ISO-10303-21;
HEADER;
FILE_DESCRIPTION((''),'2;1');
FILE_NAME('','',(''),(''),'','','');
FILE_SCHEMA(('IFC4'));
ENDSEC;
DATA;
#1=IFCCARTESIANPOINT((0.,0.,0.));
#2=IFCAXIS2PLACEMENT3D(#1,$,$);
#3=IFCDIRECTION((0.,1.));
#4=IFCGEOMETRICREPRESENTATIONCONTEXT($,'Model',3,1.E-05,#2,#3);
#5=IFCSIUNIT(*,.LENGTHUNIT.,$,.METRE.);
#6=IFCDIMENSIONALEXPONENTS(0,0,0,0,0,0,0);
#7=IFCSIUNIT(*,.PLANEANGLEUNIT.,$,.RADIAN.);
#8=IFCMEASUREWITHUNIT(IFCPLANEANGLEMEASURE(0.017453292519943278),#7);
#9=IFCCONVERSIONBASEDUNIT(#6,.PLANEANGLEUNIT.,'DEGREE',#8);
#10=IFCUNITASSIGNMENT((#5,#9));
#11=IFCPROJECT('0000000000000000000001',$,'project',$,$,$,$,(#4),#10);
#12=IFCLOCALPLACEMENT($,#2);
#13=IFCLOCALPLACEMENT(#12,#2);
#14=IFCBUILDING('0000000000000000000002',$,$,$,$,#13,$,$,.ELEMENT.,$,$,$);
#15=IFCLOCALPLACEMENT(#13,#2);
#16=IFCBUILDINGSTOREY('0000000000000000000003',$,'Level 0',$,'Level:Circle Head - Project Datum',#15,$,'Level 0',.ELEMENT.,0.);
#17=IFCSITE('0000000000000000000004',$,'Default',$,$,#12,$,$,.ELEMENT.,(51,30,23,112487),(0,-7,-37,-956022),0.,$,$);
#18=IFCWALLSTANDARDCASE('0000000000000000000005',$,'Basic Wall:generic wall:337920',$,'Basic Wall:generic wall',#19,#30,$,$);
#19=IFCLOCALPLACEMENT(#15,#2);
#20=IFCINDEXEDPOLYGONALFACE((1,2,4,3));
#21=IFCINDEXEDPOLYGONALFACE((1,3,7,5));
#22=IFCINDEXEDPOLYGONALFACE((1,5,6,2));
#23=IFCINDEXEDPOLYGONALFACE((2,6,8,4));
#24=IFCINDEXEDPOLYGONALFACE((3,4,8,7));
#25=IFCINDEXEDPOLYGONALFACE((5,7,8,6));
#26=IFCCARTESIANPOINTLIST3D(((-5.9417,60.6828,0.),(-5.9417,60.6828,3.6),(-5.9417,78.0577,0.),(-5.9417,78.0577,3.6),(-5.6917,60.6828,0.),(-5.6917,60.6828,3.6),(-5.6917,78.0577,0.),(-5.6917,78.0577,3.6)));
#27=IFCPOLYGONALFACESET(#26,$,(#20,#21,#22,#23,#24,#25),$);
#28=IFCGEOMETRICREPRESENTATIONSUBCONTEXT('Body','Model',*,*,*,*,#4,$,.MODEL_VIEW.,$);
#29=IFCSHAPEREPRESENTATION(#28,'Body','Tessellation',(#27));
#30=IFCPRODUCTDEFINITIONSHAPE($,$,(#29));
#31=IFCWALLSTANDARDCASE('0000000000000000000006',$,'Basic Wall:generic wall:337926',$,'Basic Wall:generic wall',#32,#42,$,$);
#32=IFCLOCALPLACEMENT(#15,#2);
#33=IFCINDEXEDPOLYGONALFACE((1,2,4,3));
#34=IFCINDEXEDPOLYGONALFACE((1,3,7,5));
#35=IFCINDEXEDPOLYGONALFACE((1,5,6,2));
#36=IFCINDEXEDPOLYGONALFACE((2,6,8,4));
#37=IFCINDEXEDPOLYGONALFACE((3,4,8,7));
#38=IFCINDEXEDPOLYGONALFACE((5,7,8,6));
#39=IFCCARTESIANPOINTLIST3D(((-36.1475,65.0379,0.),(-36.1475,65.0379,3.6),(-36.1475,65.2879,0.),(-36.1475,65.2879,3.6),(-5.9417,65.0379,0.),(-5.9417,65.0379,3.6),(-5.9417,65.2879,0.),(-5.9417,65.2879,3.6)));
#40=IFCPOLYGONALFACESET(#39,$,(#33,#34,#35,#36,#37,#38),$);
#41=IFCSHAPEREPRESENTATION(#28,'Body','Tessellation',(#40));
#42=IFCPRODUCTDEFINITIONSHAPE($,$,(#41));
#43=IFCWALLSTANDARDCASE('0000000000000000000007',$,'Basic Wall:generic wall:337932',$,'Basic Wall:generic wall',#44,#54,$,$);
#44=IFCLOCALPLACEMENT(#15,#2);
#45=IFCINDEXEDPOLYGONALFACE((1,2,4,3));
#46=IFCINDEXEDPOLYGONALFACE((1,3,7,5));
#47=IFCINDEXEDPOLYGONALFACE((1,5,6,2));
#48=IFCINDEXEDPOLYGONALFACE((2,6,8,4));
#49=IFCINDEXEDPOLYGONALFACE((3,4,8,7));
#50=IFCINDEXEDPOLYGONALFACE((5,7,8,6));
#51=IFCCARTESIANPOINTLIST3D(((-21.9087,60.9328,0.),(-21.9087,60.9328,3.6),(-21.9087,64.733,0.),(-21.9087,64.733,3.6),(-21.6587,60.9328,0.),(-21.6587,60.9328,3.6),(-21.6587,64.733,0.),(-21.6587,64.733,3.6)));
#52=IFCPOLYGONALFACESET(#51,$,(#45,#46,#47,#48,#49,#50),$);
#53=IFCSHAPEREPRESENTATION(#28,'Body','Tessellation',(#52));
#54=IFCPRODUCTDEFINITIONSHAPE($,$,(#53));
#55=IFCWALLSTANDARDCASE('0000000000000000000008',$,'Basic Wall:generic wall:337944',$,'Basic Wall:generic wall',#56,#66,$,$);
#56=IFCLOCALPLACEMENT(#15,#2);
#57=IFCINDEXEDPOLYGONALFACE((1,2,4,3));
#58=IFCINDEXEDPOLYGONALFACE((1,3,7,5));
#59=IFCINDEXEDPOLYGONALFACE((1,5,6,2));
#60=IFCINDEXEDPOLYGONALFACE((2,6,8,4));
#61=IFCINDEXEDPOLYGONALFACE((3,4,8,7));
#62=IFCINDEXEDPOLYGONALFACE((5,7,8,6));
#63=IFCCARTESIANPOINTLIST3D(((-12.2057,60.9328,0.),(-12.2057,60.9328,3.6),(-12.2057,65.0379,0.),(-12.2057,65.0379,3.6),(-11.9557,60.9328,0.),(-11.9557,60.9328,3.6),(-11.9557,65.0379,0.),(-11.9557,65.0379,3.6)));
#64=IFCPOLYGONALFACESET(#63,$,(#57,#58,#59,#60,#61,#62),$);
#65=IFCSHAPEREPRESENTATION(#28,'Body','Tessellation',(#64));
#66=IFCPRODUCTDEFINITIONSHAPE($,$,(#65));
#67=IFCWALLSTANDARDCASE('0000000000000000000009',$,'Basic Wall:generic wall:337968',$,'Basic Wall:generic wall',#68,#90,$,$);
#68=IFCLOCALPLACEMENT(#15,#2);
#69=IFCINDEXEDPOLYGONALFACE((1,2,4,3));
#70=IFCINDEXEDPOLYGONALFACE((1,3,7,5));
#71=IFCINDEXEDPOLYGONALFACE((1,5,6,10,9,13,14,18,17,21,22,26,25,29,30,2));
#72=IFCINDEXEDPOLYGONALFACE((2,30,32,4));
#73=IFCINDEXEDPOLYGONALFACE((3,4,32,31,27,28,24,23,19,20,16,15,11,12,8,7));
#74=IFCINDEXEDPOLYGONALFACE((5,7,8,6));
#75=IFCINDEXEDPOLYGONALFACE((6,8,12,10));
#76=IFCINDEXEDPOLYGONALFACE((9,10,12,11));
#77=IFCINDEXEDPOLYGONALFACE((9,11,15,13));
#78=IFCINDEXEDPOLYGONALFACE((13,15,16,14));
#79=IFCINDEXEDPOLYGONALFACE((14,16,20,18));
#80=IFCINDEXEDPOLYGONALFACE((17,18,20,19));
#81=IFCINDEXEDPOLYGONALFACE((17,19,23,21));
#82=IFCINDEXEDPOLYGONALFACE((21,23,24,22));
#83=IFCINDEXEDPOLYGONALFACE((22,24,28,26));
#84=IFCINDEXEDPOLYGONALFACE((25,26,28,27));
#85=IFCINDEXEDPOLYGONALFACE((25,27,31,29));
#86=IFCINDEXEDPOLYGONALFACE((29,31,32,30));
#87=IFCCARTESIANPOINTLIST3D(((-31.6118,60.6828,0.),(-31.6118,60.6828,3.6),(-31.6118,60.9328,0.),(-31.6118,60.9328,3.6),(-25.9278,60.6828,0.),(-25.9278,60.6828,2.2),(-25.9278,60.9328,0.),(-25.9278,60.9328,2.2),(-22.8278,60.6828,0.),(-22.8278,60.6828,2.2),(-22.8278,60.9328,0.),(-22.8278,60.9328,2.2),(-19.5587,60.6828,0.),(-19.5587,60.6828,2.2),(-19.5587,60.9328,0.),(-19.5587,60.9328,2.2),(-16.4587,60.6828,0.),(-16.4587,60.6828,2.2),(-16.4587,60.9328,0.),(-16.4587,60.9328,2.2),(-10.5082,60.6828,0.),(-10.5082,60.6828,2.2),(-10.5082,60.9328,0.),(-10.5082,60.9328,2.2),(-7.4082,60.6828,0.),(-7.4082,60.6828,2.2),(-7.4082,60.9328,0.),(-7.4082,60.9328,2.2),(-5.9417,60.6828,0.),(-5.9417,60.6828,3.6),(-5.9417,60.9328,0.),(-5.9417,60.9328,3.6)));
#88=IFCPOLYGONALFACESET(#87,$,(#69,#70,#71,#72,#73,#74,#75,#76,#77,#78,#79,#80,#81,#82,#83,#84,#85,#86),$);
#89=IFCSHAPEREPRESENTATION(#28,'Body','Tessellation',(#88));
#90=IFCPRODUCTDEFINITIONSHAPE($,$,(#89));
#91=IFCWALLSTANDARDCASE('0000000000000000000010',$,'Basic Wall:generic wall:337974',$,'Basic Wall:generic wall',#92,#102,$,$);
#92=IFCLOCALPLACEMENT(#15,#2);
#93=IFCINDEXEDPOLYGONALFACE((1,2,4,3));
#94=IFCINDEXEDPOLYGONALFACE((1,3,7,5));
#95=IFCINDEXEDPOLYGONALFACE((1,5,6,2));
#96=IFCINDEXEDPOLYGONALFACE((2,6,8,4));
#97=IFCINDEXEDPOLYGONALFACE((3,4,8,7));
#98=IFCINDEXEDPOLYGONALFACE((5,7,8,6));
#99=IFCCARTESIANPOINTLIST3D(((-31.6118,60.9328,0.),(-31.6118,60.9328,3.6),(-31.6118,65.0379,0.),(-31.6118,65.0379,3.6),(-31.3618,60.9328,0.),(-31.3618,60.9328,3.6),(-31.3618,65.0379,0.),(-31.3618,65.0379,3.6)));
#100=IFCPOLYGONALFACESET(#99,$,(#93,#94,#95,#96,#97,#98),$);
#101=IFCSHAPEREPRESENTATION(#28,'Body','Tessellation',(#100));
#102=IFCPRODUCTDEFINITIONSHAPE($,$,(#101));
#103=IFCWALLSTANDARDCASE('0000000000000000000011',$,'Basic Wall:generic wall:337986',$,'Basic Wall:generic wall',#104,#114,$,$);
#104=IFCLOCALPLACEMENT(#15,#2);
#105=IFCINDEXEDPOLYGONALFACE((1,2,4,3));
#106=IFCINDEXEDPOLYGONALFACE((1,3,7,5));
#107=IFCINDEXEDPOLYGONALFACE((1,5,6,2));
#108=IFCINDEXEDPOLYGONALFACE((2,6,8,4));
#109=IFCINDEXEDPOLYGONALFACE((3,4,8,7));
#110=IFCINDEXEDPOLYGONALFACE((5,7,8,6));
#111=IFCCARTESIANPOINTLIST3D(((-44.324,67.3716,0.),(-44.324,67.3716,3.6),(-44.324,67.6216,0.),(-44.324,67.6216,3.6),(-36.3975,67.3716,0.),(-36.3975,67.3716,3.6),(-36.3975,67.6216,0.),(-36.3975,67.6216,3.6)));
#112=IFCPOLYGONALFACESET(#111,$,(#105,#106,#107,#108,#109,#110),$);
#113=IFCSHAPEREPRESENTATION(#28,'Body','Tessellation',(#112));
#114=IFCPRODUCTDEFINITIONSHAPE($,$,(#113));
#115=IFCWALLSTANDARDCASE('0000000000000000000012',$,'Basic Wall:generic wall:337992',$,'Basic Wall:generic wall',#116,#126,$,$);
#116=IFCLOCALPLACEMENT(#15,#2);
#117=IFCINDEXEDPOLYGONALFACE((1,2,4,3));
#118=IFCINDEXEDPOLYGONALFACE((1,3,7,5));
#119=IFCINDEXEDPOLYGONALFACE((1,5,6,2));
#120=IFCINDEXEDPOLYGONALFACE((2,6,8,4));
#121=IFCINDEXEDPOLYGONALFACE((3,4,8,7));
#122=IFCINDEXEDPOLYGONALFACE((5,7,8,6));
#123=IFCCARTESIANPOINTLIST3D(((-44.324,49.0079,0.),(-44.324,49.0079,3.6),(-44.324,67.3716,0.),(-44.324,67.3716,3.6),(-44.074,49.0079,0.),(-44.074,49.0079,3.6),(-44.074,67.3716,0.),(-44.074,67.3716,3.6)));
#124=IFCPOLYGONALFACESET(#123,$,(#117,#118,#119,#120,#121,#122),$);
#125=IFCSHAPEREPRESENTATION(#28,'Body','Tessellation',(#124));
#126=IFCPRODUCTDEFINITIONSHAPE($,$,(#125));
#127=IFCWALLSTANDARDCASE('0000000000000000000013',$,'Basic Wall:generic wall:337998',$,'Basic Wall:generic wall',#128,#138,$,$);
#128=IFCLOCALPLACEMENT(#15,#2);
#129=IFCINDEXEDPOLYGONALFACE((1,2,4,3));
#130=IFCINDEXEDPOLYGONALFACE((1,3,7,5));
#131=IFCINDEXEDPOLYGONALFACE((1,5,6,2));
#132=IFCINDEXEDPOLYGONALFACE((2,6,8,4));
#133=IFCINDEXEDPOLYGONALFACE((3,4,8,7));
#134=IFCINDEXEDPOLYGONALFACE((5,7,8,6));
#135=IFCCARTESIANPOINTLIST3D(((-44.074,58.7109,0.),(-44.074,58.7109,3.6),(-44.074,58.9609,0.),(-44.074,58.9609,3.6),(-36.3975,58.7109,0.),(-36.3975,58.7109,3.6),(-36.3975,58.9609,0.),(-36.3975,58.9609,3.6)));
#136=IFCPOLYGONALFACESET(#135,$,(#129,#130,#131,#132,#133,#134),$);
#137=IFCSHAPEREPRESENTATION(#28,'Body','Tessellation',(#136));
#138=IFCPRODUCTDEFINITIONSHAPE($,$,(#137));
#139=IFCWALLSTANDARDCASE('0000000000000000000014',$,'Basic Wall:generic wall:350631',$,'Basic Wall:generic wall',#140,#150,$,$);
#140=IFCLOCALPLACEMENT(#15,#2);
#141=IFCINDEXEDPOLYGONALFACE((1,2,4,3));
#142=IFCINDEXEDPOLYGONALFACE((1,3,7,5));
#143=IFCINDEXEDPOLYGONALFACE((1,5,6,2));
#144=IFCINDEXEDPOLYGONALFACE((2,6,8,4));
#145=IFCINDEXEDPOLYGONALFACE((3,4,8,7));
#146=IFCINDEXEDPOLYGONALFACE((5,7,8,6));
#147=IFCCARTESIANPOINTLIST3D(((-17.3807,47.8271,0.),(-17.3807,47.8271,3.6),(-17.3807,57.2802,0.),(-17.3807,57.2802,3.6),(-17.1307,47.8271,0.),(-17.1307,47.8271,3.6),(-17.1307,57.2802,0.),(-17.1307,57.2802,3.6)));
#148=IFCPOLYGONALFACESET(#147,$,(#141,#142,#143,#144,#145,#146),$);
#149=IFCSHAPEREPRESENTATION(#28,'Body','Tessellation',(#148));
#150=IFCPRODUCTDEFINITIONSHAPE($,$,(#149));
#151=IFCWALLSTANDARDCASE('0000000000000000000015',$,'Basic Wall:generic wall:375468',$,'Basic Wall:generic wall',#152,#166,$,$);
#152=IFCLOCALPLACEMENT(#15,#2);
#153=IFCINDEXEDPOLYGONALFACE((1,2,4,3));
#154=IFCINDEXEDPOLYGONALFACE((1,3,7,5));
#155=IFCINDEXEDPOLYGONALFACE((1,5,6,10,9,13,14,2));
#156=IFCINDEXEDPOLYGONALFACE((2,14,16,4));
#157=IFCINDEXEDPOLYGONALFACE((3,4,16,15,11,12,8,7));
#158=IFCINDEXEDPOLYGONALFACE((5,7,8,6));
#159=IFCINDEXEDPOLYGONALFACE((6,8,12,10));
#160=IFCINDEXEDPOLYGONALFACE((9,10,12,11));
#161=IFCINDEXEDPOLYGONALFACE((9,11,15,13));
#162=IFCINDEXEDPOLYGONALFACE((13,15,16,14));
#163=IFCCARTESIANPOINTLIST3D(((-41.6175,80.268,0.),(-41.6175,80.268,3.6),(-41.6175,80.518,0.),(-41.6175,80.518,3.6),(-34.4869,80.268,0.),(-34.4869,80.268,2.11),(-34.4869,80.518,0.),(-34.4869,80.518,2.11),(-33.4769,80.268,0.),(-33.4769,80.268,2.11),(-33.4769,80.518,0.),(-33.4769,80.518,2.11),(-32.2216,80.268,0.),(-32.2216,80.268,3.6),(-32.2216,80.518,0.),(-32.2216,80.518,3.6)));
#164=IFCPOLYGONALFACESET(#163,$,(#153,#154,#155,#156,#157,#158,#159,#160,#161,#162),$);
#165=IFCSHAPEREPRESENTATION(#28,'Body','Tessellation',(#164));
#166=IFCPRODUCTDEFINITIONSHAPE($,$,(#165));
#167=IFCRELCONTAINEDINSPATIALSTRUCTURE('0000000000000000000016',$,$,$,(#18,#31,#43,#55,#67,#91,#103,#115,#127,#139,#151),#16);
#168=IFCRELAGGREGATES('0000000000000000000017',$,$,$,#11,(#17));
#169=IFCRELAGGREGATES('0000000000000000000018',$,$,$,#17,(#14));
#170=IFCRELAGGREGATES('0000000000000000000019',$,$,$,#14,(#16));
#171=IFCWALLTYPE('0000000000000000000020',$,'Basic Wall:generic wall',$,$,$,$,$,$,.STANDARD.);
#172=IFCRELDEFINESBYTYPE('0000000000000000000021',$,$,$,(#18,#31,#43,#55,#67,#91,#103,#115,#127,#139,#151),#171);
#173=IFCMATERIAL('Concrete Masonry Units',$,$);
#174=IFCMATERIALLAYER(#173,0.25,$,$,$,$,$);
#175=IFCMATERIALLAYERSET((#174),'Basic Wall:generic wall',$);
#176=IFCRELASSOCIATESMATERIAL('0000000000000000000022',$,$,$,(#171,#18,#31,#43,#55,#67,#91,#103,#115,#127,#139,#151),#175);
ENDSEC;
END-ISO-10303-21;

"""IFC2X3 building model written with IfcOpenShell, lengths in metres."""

from ifc_helpers import new_model, entity, si_unit, converted_unit, direction, frame, frame_2d, origin, place, context, subcontext, project, spatial, rectangle, extrude, material, layer, layer_set, layer_usage, type_object, element, save


model = new_model("IFC2X3")

# Units and contexts
model_context = context("Model", 3, precision=1e-05, world=origin(), true_north=direction((0.0, 1.0)))
body_context = subcontext(model_context, "Body", "Model", "MODEL_VIEW")
ifc_project = project(units=[si_unit("LENGTHUNIT", "METRE"), converted_unit("PLANEANGLEUNIT", "DEGREE", entity("IfcPlaneAngleMeasure", 0.017453292519943278), si_unit("PLANEANGLEUNIT", "RADIAN"), dimensions=[0, 0, 0, 0, 0, 0, 0])], contexts=[model_context])

# Site, building, storey
site_placement = place(None, origin())
site = spatial("IfcSite", under=ifc_project, at=site_placement, Name="Default", CompositionType="ELEMENT", RefLatitude=(51, 30, 23, 112487), RefLongitude=(0, -7, -37, -956022), RefElevation=0.0)
building_placement = place(site_placement, origin())
building = spatial("IfcBuilding", under=site, at=building_placement, CompositionType="ELEMENT")
storey_placement = place(building_placement, origin())
storey = spatial("IfcBuildingStorey", under=building, at=storey_placement, Name="Level 0", ObjectType="Level:Circle Head - Project Datum", LongName="Level 0", CompositionType="ELEMENT", Elevation=0.0)

# Shared definitions
ifc_material = material(Name="Concrete Masonry Units")
ifc_layer = layer(ifc_material, 0.25)
ifc_layer_set = layer_set([ifc_layer], Name="Basic Wall:generic wall")
wall_type = type_object("IfcWallType", Name="Basic Wall:generic wall", PredefinedType="STANDARD", material=ifc_layer_set)

# Walls
ifc_layer_usage_1 = layer_usage(ifc_layer_set, "AXIS2", "NEGATIVE", 0.125)
wall_1_placement = place(storey_placement, frame((-5.8167, 78.0577, 0.0), z_axis=(0.0, 0.0, 1.0), x_axis=(0.0, -1.0, 0.0)))
element("IfcWallStandardCase", 1, at=wall_1_placement, inside=storey, type_object=wall_type, material=ifc_layer_usage_1, Name="Basic Wall:generic wall:337920", ObjectType="Basic Wall:generic wall", context=body_context, shape_type="SweptSolid", body=[
    extrude(rectangle(XDim=17.3749, YDim=0.25, at=frame_2d((8.6874, 0.0), x_axis=(-1.0, 0.0))), origin(), (0.0, 0.0, 1.0), 3.6),
])
ifc_layer_usage_2 = layer_usage(ifc_layer_set, "AXIS2", "NEGATIVE", 0.125)
wall_2_placement = place(storey_placement, frame((-5.9417, 65.1629, 0.0), z_axis=(0.0, 0.0, 1.0), x_axis=(-1.0, 0.0, 0.0)))
element("IfcWallStandardCase", 2, at=wall_2_placement, inside=storey, type_object=wall_type, material=ifc_layer_usage_2, Name="Basic Wall:generic wall:337926", ObjectType="Basic Wall:generic wall", context=body_context, shape_type="SweptSolid", body=[
    extrude(rectangle(XDim=30.2059, YDim=0.25, at=frame_2d((15.1029, 0.0), x_axis=(-1.0, 0.0))), origin(), (0.0, 0.0, 1.0), 3.6),
])
ifc_layer_usage_3 = layer_usage(ifc_layer_set, "AXIS2", "NEGATIVE", 0.125)
wall_3_placement = place(storey_placement, frame((-21.7837, 64.733, 0.0), z_axis=(0.0, 0.0, 1.0), x_axis=(0.0, -1.0, 0.0)))
element("IfcWallStandardCase", 3, at=wall_3_placement, inside=storey, type_object=wall_type, material=ifc_layer_usage_3, Name="Basic Wall:generic wall:337932", ObjectType="Basic Wall:generic wall", context=body_context, shape_type="SweptSolid", body=[
    extrude(rectangle(XDim=3.8003, YDim=0.25, at=frame_2d((1.9001, 0.0), x_axis=(-1.0, 0.0))), origin(), (0.0, 0.0, 1.0), 3.6),
])
ifc_layer_usage_4 = layer_usage(ifc_layer_set, "AXIS2", "NEGATIVE", 0.125)
wall_4_placement = place(storey_placement, frame((-12.0807, 65.0379, 0.0), z_axis=(0.0, 0.0, 1.0), x_axis=(0.0, -1.0, 0.0)))
element("IfcWallStandardCase", 4, at=wall_4_placement, inside=storey, type_object=wall_type, material=ifc_layer_usage_4, Name="Basic Wall:generic wall:337944", ObjectType="Basic Wall:generic wall", context=body_context, shape_type="SweptSolid", body=[
    extrude(rectangle(XDim=4.1051, YDim=0.25, at=frame_2d((2.0526, 0.0), x_axis=(-1.0, 0.0))), origin(), (0.0, 0.0, 1.0), 3.6),
])

# Wall, openings
ifc_layer_usage_5 = layer_usage(ifc_layer_set, "AXIS2", "NEGATIVE", 0.125)
wall_5_placement = place(storey_placement, frame((-5.9417, 60.8078, 0.0), z_axis=(0.0, 0.0, 1.0), x_axis=(-1.0, 0.0, 0.0)))
wall_5 = element("IfcWallStandardCase", 5, at=wall_5_placement, inside=storey, type_object=wall_type, material=ifc_layer_usage_5, Name="Basic Wall:generic wall:337968", ObjectType="Basic Wall:generic wall", context=body_context, shape_type="SweptSolid", body=[
    extrude(rectangle(XDim=25.6701, YDim=0.25, at=frame_2d((12.8351, 0.0), x_axis=(1.0, 0.0))), origin(), (0.0, 0.0, 1.0), 3.6),
])
opening_1_placement = place(wall_5_placement, frame((19.9861, 0.125, 0.0)))
element("IfcOpeningElement", 6, at=opening_1_placement, cuts=wall_5, ObjectType="Opening", context=body_context, shape_type="SweptSolid", body=[
    extrude(rectangle(XDim=2.2, YDim=3.1, at=frame_2d((1.1, 1.55), x_axis=(1.0, 0.0))), frame((0.0, 0.0, 0.0), z_axis=(0.0, -1.0, 0.0), x_axis=(0.0, 0.0, 1.0)), (0.0, 0.0, 1.0), 0.25),
])
opening_2_placement = place(wall_5_placement, frame((13.6171, 0.125, 0.0)))
element("IfcOpeningElement", 7, at=opening_2_placement, cuts=wall_5, ObjectType="Opening", context=body_context, shape_type="SweptSolid", body=[
    extrude(rectangle(XDim=2.2, YDim=3.1, at=frame_2d((1.1, 1.55), x_axis=(1.0, 0.0))), frame((0.0, 0.0, 0.0), z_axis=(0.0, -1.0, 0.0), x_axis=(0.0, 0.0, 1.0)), (0.0, 0.0, 1.0), 0.25),
])
opening_3_placement = place(wall_5_placement, frame((4.5665, 0.125, 0.0)))
element("IfcOpeningElement", 8, at=opening_3_placement, cuts=wall_5, ObjectType="Opening", context=body_context, shape_type="SweptSolid", body=[
    extrude(rectangle(XDim=2.2, YDim=3.1, at=frame_2d((1.1, 1.55), x_axis=(1.0, 0.0))), frame((0.0, 0.0, 0.0), z_axis=(0.0, -1.0, 0.0), x_axis=(0.0, 0.0, 1.0)), (0.0, 0.0, 1.0), 0.25),
])

# Walls
ifc_layer_usage_6 = layer_usage(ifc_layer_set, "AXIS2", "NEGATIVE", 0.125)
wall_6_placement = place(storey_placement, frame((-31.4868, 65.0379, 0.0), z_axis=(0.0, 0.0, 1.0), x_axis=(0.0, -1.0, 0.0)))
element("IfcWallStandardCase", 9, at=wall_6_placement, inside=storey, type_object=wall_type, material=ifc_layer_usage_6, Name="Basic Wall:generic wall:337974", ObjectType="Basic Wall:generic wall", context=body_context, shape_type="SweptSolid", body=[
    extrude(rectangle(XDim=4.1051, YDim=0.25, at=frame_2d((2.0526, 0.0), x_axis=(-1.0, 0.0))), origin(), (0.0, 0.0, 1.0), 3.6),
])
ifc_layer_usage_7 = layer_usage(ifc_layer_set, "AXIS2", "NEGATIVE", 0.125)
wall_7_placement = place(storey_placement, frame((-36.3975, 67.4966, 0.0), z_axis=(0.0, 0.0, 1.0), x_axis=(-1.0, 0.0, 0.0)))
element("IfcWallStandardCase", 10, at=wall_7_placement, inside=storey, type_object=wall_type, material=ifc_layer_usage_7, Name="Basic Wall:generic wall:337986", ObjectType="Basic Wall:generic wall", context=body_context, shape_type="SweptSolid", body=[
    extrude(rectangle(XDim=7.9265, YDim=0.25, at=frame_2d((3.9632, 0.0), x_axis=(-1.0, 0.0))), origin(), (0.0, 0.0, 1.0), 3.6),
])
ifc_layer_usage_8 = layer_usage(ifc_layer_set, "AXIS2", "NEGATIVE", 0.125)
wall_8_placement = place(storey_placement, frame((-44.199, 67.3716, 0.0), z_axis=(0.0, 0.0, 1.0), x_axis=(0.0, -1.0, 0.0)))
element("IfcWallStandardCase", 11, at=wall_8_placement, inside=storey, type_object=wall_type, material=ifc_layer_usage_8, Name="Basic Wall:generic wall:337992", ObjectType="Basic Wall:generic wall", context=body_context, shape_type="SweptSolid", body=[
    extrude(rectangle(XDim=18.3637, YDim=0.25, at=frame_2d((9.1819, 0.0), x_axis=(-1.0, 0.0))), origin(), (0.0, 0.0, 1.0), 3.6),
])
ifc_layer_usage_9 = layer_usage(ifc_layer_set, "AXIS2", "NEGATIVE", 0.125)
wall_9_placement = place(storey_placement, frame((-44.074, 58.8359, 0.0)))
element("IfcWallStandardCase", 12, at=wall_9_placement, inside=storey, type_object=wall_type, material=ifc_layer_usage_9, Name="Basic Wall:generic wall:337998", ObjectType="Basic Wall:generic wall", context=body_context, shape_type="SweptSolid", body=[
    extrude(rectangle(XDim=7.6765, YDim=0.25, at=frame_2d((3.8382, 0.0), x_axis=(-1.0, 0.0))), origin(), (0.0, 0.0, 1.0), 3.6),
])
ifc_layer_usage_10 = layer_usage(ifc_layer_set, "AXIS2", "NEGATIVE", 0.125)
wall_10_placement = place(storey_placement, frame((-17.2557, 57.2802, 0.0), z_axis=(0.0, 0.0, 1.0), x_axis=(0.0, -1.0, 0.0)))
element("IfcWallStandardCase", 13, at=wall_10_placement, inside=storey, type_object=wall_type, material=ifc_layer_usage_10, Name="Basic Wall:generic wall:350631", ObjectType="Basic Wall:generic wall", context=body_context, shape_type="SweptSolid", body=[
    extrude(rectangle(XDim=9.4531, YDim=0.25, at=frame_2d((4.7265, 0.0), x_axis=(-1.0, 0.0))), origin(), (0.0, 0.0, 1.0), 3.6),
])

# Wall, opening
ifc_layer_usage_11 = layer_usage(ifc_layer_set, "AXIS2", "POSITIVE", -0.125)
wall_11_placement = place(storey_placement, frame((-41.6175, 80.393, 0.0)))
wall_11 = element("IfcWallStandardCase", 14, at=wall_11_placement, inside=storey, type_object=wall_type, material=ifc_layer_usage_11, Name="Basic Wall:generic wall:375468", ObjectType="Basic Wall:generic wall", context=body_context, shape_type="SweptSolid", body=[
    extrude(rectangle(XDim=9.396, YDim=0.25, at=frame_2d((4.698, 0.0), x_axis=(-1.0, 0.0))), origin(), (0.0, 0.0, 1.0), 3.6),
])
opening_4_placement = place(wall_11_placement, frame((7.1307, -0.125, 0.0)))
element("IfcOpeningElement", 15, at=opening_4_placement, cuts=wall_11, ObjectType="Opening", context=body_context, shape_type="SweptSolid", body=[
    extrude(rectangle(XDim=2.11, YDim=1.01, at=frame_2d((1.055, 0.505), x_axis=(1.0, 0.0))), frame((0.0, 0.0, 0.0), z_axis=(0.0, 1.0, 0.0), x_axis=(0.0, 0.0, 1.0)), (0.0, 0.0, 1.0), 0.25),
])

save(model, "model.ifc")
